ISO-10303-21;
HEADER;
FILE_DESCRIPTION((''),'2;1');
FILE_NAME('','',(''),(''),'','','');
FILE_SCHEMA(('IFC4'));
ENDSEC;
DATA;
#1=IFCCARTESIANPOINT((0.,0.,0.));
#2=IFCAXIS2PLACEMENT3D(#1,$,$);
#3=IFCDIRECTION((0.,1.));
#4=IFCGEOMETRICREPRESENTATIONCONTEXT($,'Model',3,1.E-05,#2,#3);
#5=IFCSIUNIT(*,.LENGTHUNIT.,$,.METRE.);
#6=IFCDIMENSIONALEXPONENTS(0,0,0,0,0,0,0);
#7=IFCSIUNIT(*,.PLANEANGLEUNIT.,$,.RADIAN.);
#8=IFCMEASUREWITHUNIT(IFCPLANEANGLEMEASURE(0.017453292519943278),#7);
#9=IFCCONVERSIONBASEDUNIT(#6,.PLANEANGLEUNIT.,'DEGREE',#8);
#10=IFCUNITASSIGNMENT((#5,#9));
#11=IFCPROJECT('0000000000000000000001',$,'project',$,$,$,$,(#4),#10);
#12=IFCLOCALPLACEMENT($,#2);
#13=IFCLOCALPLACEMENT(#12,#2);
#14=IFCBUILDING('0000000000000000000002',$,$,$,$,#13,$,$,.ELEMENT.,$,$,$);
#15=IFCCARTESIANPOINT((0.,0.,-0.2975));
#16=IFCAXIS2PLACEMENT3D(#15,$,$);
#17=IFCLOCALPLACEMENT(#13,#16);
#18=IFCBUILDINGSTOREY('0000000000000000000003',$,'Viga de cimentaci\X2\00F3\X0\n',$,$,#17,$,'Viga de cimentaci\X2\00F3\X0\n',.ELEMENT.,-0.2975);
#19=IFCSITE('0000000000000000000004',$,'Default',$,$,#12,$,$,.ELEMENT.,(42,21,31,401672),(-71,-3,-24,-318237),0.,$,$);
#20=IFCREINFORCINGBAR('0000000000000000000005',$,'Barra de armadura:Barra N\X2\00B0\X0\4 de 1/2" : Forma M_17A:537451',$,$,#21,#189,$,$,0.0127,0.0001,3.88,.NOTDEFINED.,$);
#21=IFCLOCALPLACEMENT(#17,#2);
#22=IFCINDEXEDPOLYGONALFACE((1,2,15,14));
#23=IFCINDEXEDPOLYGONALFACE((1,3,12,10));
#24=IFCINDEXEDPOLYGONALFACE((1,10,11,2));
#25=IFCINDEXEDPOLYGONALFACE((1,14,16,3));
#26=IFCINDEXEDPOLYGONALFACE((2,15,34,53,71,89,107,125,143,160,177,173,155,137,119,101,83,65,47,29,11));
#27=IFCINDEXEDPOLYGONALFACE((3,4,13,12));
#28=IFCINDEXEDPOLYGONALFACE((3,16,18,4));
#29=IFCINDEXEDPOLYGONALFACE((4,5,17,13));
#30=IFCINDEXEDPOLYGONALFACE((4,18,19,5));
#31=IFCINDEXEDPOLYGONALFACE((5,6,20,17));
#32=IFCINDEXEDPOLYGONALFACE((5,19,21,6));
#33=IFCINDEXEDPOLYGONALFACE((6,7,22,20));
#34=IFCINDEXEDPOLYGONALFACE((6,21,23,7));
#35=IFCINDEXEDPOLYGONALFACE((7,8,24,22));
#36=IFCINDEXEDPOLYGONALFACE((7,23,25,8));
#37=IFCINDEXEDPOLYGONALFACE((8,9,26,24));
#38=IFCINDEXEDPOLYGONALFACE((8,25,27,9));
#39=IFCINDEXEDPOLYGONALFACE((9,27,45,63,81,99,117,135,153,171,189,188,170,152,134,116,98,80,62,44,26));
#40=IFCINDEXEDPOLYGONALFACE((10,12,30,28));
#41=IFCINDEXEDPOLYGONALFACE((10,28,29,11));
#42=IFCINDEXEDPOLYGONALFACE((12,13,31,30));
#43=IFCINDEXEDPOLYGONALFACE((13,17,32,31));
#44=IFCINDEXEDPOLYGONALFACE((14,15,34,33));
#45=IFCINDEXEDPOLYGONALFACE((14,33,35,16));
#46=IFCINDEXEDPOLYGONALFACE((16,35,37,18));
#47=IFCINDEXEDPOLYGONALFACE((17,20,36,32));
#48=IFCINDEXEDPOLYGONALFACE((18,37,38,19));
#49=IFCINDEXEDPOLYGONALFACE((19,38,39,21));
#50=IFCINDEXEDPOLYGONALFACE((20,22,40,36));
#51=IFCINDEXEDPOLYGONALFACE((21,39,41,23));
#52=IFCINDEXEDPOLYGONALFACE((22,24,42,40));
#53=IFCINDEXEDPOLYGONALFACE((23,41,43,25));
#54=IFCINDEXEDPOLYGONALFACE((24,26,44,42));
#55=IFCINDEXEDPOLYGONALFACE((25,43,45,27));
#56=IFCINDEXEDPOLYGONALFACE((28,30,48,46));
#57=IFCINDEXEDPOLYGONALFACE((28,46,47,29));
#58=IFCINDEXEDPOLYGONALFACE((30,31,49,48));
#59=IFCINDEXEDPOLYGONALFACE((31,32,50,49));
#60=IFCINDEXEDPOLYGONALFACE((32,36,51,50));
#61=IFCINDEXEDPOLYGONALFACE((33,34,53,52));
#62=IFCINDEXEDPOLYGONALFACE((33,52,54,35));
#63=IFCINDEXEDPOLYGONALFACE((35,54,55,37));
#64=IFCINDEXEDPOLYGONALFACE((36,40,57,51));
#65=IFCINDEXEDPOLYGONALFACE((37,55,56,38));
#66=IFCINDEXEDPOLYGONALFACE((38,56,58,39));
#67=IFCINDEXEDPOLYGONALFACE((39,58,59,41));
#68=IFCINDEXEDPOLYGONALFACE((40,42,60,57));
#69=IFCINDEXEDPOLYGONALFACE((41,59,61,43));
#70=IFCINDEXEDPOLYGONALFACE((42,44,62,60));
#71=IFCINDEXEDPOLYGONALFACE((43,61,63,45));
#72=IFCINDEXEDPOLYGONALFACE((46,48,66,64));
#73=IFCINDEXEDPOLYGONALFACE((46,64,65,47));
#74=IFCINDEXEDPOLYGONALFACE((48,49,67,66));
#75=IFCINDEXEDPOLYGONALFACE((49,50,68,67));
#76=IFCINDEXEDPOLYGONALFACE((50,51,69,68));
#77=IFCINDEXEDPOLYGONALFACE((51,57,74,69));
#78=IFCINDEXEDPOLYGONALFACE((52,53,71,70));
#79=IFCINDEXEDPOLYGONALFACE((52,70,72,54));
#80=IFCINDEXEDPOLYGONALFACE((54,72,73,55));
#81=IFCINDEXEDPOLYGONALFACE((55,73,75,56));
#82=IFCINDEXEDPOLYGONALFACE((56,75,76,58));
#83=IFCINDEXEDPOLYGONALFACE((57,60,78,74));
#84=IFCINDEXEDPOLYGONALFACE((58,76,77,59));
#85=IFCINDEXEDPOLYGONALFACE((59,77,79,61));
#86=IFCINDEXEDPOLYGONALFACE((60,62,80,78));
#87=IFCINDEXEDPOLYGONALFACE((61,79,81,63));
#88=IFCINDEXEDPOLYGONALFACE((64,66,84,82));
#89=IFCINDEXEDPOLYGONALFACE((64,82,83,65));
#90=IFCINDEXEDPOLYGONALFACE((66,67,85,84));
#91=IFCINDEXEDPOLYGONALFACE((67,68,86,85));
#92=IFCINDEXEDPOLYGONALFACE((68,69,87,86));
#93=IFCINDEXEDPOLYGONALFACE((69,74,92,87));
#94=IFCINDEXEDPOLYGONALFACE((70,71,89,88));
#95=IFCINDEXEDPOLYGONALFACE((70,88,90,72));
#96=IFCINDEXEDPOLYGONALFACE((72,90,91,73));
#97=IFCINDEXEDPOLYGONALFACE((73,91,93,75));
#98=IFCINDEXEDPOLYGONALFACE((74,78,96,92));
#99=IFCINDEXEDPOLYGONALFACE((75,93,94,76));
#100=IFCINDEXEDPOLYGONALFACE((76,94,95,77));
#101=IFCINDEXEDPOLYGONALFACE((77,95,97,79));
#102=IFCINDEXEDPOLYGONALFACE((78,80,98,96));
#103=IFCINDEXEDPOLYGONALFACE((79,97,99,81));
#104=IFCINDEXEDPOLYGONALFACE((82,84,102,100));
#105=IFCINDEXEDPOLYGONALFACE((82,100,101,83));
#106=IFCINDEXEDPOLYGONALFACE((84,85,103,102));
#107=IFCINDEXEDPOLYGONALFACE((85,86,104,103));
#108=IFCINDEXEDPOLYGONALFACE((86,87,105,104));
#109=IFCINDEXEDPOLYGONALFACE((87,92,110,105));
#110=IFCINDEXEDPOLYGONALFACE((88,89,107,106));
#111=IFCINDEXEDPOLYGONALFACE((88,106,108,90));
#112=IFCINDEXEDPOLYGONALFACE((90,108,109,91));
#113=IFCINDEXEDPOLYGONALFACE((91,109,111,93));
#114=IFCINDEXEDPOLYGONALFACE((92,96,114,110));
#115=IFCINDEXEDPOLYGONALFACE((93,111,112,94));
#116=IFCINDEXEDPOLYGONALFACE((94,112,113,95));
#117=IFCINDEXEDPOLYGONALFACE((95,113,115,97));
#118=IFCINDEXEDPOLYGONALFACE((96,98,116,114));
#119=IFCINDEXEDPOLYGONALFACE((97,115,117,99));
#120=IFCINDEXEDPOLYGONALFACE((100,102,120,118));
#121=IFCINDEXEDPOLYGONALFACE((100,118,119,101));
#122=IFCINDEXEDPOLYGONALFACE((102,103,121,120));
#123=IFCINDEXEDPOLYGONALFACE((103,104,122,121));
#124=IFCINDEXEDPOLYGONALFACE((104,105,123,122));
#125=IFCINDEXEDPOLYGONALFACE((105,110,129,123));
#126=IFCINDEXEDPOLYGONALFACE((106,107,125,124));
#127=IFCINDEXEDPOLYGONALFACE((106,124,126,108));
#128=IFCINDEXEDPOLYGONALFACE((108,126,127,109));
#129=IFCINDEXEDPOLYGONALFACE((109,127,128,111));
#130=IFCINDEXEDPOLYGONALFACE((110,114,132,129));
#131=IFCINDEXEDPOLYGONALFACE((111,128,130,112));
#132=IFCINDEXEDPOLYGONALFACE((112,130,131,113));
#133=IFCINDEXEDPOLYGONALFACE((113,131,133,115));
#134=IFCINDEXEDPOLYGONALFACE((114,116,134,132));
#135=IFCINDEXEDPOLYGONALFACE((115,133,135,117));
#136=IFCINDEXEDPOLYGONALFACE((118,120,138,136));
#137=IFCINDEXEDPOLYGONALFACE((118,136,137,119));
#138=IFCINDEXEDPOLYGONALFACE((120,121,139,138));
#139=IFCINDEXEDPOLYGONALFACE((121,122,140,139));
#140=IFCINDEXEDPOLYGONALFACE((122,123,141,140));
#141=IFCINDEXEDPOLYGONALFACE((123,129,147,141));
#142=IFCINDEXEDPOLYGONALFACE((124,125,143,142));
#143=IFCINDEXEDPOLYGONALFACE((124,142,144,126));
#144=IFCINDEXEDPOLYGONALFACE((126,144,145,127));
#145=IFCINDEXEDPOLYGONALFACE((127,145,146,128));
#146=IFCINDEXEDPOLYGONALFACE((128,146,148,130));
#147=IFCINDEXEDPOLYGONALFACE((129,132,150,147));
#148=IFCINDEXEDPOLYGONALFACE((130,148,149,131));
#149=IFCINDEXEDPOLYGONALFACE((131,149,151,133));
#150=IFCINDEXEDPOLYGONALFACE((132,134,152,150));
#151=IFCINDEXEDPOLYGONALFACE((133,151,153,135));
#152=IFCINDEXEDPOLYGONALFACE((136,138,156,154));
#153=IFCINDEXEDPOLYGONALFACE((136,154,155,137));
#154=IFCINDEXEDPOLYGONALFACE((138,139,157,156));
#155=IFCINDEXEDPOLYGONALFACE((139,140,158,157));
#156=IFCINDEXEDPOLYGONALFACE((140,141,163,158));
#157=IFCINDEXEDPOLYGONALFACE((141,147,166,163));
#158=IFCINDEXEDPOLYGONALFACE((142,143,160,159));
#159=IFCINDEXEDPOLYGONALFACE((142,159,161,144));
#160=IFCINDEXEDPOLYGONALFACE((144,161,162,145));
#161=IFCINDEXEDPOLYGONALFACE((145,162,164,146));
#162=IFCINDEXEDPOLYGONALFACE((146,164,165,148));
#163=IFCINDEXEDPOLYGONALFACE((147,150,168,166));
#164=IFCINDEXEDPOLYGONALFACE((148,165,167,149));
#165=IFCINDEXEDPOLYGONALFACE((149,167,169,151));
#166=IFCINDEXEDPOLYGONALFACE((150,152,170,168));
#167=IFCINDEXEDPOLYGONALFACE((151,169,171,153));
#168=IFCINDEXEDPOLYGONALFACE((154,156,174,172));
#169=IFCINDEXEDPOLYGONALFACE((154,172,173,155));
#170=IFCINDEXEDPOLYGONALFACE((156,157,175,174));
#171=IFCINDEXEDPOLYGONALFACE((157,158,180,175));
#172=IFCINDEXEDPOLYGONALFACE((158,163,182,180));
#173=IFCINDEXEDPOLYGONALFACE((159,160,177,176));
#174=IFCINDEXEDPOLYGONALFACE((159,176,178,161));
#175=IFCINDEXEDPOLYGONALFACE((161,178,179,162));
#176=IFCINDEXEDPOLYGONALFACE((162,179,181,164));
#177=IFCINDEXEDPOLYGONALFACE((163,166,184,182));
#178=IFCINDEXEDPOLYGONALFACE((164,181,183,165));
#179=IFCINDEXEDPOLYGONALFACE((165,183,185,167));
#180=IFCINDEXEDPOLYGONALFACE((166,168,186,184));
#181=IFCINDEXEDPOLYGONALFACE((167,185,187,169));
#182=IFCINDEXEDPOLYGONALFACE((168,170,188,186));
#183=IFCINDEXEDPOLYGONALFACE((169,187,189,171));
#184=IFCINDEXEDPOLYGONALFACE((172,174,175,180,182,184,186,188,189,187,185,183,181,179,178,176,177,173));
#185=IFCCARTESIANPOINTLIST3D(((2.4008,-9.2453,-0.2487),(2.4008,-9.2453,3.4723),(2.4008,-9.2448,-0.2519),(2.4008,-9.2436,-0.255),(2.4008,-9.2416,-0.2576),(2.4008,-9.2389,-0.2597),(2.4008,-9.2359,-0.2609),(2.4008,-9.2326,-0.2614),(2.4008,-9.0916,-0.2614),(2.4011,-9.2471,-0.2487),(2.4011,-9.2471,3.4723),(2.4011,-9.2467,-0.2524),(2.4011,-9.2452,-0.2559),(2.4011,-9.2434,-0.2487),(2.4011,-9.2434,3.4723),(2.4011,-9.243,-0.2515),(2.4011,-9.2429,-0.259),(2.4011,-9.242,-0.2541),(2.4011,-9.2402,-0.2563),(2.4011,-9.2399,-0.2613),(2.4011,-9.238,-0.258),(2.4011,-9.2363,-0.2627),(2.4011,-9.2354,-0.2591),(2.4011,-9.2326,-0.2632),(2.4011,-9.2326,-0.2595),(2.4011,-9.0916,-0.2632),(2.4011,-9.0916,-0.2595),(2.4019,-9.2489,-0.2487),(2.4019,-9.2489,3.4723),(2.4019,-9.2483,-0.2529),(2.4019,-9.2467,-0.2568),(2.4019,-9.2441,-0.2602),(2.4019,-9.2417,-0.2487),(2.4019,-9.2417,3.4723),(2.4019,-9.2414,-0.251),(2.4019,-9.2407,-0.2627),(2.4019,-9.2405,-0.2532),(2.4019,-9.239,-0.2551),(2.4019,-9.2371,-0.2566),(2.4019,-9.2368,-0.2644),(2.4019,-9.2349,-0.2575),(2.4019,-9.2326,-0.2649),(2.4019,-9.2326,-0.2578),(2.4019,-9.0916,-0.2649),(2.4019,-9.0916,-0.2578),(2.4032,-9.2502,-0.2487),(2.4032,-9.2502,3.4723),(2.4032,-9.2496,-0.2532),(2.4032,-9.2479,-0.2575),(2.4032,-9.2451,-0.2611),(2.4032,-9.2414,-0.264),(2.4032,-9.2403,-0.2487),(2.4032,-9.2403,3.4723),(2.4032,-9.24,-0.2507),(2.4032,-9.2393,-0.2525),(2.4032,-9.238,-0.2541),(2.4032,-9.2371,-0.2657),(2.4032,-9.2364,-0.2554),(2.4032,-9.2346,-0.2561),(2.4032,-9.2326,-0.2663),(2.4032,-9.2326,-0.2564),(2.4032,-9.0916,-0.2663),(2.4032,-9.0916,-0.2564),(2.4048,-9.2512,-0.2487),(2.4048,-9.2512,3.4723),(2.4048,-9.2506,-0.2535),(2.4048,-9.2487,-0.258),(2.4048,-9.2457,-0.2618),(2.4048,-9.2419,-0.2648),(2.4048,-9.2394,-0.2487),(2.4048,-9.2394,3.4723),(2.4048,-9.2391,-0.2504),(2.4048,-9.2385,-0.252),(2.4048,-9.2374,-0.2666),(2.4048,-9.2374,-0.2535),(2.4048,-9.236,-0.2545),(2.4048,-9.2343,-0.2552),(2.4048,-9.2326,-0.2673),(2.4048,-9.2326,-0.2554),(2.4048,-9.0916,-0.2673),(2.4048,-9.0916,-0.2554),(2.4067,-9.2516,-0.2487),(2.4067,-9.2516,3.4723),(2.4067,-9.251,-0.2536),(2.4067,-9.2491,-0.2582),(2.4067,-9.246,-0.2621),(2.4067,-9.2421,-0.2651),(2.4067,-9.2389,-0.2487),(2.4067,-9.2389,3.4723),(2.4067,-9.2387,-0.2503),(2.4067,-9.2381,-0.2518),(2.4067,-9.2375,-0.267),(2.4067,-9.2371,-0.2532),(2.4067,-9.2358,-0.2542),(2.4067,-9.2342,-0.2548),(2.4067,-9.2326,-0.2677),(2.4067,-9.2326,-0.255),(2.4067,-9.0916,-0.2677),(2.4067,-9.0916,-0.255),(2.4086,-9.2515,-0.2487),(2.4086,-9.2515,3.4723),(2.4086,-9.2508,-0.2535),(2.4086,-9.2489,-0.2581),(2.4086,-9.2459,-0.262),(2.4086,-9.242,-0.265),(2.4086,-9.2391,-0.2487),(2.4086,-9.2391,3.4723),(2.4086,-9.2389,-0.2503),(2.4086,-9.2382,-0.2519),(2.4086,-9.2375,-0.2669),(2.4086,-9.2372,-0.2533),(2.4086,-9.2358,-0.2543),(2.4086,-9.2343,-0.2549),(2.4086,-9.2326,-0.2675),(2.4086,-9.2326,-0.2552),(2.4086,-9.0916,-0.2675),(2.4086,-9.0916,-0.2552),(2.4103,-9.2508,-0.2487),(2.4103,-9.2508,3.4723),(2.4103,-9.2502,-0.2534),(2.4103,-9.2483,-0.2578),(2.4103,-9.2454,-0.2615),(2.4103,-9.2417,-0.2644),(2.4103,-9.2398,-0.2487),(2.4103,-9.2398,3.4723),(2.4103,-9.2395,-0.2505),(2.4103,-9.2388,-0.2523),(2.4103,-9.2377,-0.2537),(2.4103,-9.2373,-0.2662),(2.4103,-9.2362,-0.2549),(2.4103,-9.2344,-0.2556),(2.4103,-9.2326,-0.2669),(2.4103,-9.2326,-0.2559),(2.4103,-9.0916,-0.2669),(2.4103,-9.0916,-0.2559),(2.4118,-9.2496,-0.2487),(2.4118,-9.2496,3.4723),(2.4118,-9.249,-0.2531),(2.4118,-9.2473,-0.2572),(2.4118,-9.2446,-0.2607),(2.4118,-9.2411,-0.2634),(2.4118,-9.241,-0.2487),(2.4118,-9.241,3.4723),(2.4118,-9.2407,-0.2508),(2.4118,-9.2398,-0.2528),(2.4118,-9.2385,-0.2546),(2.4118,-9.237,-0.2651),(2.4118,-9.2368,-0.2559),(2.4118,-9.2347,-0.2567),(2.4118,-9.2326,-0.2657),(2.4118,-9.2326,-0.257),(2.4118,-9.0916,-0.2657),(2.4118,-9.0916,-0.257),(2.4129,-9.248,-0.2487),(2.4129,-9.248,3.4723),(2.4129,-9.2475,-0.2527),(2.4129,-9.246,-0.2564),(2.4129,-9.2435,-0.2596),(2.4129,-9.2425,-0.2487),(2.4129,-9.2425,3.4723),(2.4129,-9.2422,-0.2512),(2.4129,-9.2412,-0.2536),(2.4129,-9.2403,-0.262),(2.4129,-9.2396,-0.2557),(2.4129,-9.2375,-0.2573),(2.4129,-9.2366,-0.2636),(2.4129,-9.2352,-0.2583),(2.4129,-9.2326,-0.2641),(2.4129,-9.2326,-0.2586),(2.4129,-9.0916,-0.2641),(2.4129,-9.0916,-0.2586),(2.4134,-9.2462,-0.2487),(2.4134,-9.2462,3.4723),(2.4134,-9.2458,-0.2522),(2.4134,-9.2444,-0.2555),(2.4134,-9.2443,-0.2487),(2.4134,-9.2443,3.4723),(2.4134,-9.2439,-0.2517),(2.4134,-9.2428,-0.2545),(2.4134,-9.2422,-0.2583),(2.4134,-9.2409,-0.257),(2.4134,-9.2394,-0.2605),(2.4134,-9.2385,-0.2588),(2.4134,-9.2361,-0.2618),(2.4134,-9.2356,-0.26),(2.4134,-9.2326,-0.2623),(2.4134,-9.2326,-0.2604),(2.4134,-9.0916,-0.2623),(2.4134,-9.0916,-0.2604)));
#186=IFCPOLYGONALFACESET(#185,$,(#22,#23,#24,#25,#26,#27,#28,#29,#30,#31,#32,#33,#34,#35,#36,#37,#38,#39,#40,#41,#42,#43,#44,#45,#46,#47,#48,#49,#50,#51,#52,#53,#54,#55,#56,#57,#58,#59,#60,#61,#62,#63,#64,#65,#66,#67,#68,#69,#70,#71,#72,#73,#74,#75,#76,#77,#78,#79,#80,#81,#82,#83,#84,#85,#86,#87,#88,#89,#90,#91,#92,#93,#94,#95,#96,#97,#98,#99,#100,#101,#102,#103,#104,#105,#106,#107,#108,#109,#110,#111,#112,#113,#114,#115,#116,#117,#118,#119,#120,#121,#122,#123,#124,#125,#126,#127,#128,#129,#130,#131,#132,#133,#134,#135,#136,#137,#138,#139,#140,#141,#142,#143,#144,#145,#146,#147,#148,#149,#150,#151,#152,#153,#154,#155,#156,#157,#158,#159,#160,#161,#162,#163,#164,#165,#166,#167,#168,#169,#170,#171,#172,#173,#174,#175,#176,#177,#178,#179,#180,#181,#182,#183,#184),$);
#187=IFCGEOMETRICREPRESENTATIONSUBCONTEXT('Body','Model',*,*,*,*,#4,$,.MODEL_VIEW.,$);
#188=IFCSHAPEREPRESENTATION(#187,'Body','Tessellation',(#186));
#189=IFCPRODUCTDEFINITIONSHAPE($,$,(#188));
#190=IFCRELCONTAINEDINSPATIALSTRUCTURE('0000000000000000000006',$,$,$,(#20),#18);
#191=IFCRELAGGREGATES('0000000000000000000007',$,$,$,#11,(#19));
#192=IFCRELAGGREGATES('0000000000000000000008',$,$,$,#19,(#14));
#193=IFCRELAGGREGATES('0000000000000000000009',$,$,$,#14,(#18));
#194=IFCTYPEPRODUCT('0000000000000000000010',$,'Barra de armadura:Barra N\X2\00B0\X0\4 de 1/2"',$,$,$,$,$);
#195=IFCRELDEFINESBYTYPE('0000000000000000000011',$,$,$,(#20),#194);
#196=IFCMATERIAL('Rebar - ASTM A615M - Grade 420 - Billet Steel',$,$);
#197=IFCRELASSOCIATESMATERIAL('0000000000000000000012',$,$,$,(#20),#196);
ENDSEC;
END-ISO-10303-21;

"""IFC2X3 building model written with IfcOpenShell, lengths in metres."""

from ifc_helpers import new_model, entity, si_unit, converted_unit, direction, frame, origin, place, context, subcontext, project, spatial, material, type_object, element, save


model = new_model("IFC2X3")

# Units and contexts
model_context = context("Model", 3, precision=1e-05, world=origin(), true_north=direction((0.0, 1.0)))
body_context = subcontext(model_context, "Body", "Model", "MODEL_VIEW")
ifc_project = project(units=[si_unit("LENGTHUNIT", "METRE"), converted_unit("PLANEANGLEUNIT", "DEGREE", entity("IfcPlaneAngleMeasure", 0.017453292519943278), si_unit("PLANEANGLEUNIT", "RADIAN"), dimensions=[0, 0, 0, 0, 0, 0, 0])], contexts=[model_context])

# Site, building, storey
site_placement = place(None, origin())
site = spatial("IfcSite", under=ifc_project, at=site_placement, Name="Default", CompositionType="ELEMENT", RefLatitude=(42, 21, 31, 401672), RefLongitude=(-71, -3, -24, -318237), RefElevation=0.0)
building_placement = place(site_placement, origin())
building = spatial("IfcBuilding", under=site, at=building_placement, CompositionType="ELEMENT")
storey_placement = place(building_placement, frame((0.0, 0.0, -0.2975)))
storey = spatial("IfcBuildingStorey", under=building, at=storey_placement, Name="Viga de cimentación", LongName="Viga de cimentación", CompositionType="ELEMENT", Elevation=-0.2975)

# Reinforcing bar
ifc_material = material(Name="Rebar - ASTM A615M - Grade 420 - Billet Steel")
type_product_1 = type_object("IfcTypeProduct", Name="Barra de armadura:Barra N°4 de 1/2\"")
reinforcing_bar_1_placement = place(storey_placement, origin())
element("IfcReinforcingBar", 1, at=reinforcing_bar_1_placement, inside=storey, type_object=type_product_1, material=ifc_material, Name="Barra de armadura:Barra N°4 de 1/2\" : Forma M_17A:537451", BarLength=3.88, BarRole="NOTDEFINED", CrossSectionArea=0.0001, NominalDiameter=0.0127, context=body_context, shape_type="AdvancedSweptSolid", body=[
    entity("IfcSweptDiskSolid", entity("IfcCompositeCurve", [entity("IfcCompositeCurveSegment", "CONTINUOUS", True, entity("IfcPolyline", [entity("IfcCartesianPoint", [2.4071, -9.2453, 3.4723]), entity("IfcCartesianPoint", [2.4071, -9.2453, -0.2487])])), entity("IfcCompositeCurveSegment", "CONTINUOUS", True, entity("IfcTrimmedCurve", entity("IfcCircle", entity("IfcAxis2Placement3D", entity("IfcCartesianPoint", [2.4071, -9.2326, -0.2487]), entity("IfcDirection", [1.0, 0.0, 0.0]), entity("IfcDirection", [0.0, 0.0, -1.0])), 0.0127), [entity("IfcParameterValue", 270.0)], [entity("IfcParameterValue", 360.0)], True, "PARAMETER")), entity("IfcCompositeCurveSegment", "CONTINUOUS", True, entity("IfcPolyline", [entity("IfcCartesianPoint", [2.4071, -9.2326, -0.2614]), entity("IfcCartesianPoint", [2.4071, -9.0916, -0.2614])]))], False), 0.0063, None, 0.0, 92.0),
])

save(model, "model.ifc")
